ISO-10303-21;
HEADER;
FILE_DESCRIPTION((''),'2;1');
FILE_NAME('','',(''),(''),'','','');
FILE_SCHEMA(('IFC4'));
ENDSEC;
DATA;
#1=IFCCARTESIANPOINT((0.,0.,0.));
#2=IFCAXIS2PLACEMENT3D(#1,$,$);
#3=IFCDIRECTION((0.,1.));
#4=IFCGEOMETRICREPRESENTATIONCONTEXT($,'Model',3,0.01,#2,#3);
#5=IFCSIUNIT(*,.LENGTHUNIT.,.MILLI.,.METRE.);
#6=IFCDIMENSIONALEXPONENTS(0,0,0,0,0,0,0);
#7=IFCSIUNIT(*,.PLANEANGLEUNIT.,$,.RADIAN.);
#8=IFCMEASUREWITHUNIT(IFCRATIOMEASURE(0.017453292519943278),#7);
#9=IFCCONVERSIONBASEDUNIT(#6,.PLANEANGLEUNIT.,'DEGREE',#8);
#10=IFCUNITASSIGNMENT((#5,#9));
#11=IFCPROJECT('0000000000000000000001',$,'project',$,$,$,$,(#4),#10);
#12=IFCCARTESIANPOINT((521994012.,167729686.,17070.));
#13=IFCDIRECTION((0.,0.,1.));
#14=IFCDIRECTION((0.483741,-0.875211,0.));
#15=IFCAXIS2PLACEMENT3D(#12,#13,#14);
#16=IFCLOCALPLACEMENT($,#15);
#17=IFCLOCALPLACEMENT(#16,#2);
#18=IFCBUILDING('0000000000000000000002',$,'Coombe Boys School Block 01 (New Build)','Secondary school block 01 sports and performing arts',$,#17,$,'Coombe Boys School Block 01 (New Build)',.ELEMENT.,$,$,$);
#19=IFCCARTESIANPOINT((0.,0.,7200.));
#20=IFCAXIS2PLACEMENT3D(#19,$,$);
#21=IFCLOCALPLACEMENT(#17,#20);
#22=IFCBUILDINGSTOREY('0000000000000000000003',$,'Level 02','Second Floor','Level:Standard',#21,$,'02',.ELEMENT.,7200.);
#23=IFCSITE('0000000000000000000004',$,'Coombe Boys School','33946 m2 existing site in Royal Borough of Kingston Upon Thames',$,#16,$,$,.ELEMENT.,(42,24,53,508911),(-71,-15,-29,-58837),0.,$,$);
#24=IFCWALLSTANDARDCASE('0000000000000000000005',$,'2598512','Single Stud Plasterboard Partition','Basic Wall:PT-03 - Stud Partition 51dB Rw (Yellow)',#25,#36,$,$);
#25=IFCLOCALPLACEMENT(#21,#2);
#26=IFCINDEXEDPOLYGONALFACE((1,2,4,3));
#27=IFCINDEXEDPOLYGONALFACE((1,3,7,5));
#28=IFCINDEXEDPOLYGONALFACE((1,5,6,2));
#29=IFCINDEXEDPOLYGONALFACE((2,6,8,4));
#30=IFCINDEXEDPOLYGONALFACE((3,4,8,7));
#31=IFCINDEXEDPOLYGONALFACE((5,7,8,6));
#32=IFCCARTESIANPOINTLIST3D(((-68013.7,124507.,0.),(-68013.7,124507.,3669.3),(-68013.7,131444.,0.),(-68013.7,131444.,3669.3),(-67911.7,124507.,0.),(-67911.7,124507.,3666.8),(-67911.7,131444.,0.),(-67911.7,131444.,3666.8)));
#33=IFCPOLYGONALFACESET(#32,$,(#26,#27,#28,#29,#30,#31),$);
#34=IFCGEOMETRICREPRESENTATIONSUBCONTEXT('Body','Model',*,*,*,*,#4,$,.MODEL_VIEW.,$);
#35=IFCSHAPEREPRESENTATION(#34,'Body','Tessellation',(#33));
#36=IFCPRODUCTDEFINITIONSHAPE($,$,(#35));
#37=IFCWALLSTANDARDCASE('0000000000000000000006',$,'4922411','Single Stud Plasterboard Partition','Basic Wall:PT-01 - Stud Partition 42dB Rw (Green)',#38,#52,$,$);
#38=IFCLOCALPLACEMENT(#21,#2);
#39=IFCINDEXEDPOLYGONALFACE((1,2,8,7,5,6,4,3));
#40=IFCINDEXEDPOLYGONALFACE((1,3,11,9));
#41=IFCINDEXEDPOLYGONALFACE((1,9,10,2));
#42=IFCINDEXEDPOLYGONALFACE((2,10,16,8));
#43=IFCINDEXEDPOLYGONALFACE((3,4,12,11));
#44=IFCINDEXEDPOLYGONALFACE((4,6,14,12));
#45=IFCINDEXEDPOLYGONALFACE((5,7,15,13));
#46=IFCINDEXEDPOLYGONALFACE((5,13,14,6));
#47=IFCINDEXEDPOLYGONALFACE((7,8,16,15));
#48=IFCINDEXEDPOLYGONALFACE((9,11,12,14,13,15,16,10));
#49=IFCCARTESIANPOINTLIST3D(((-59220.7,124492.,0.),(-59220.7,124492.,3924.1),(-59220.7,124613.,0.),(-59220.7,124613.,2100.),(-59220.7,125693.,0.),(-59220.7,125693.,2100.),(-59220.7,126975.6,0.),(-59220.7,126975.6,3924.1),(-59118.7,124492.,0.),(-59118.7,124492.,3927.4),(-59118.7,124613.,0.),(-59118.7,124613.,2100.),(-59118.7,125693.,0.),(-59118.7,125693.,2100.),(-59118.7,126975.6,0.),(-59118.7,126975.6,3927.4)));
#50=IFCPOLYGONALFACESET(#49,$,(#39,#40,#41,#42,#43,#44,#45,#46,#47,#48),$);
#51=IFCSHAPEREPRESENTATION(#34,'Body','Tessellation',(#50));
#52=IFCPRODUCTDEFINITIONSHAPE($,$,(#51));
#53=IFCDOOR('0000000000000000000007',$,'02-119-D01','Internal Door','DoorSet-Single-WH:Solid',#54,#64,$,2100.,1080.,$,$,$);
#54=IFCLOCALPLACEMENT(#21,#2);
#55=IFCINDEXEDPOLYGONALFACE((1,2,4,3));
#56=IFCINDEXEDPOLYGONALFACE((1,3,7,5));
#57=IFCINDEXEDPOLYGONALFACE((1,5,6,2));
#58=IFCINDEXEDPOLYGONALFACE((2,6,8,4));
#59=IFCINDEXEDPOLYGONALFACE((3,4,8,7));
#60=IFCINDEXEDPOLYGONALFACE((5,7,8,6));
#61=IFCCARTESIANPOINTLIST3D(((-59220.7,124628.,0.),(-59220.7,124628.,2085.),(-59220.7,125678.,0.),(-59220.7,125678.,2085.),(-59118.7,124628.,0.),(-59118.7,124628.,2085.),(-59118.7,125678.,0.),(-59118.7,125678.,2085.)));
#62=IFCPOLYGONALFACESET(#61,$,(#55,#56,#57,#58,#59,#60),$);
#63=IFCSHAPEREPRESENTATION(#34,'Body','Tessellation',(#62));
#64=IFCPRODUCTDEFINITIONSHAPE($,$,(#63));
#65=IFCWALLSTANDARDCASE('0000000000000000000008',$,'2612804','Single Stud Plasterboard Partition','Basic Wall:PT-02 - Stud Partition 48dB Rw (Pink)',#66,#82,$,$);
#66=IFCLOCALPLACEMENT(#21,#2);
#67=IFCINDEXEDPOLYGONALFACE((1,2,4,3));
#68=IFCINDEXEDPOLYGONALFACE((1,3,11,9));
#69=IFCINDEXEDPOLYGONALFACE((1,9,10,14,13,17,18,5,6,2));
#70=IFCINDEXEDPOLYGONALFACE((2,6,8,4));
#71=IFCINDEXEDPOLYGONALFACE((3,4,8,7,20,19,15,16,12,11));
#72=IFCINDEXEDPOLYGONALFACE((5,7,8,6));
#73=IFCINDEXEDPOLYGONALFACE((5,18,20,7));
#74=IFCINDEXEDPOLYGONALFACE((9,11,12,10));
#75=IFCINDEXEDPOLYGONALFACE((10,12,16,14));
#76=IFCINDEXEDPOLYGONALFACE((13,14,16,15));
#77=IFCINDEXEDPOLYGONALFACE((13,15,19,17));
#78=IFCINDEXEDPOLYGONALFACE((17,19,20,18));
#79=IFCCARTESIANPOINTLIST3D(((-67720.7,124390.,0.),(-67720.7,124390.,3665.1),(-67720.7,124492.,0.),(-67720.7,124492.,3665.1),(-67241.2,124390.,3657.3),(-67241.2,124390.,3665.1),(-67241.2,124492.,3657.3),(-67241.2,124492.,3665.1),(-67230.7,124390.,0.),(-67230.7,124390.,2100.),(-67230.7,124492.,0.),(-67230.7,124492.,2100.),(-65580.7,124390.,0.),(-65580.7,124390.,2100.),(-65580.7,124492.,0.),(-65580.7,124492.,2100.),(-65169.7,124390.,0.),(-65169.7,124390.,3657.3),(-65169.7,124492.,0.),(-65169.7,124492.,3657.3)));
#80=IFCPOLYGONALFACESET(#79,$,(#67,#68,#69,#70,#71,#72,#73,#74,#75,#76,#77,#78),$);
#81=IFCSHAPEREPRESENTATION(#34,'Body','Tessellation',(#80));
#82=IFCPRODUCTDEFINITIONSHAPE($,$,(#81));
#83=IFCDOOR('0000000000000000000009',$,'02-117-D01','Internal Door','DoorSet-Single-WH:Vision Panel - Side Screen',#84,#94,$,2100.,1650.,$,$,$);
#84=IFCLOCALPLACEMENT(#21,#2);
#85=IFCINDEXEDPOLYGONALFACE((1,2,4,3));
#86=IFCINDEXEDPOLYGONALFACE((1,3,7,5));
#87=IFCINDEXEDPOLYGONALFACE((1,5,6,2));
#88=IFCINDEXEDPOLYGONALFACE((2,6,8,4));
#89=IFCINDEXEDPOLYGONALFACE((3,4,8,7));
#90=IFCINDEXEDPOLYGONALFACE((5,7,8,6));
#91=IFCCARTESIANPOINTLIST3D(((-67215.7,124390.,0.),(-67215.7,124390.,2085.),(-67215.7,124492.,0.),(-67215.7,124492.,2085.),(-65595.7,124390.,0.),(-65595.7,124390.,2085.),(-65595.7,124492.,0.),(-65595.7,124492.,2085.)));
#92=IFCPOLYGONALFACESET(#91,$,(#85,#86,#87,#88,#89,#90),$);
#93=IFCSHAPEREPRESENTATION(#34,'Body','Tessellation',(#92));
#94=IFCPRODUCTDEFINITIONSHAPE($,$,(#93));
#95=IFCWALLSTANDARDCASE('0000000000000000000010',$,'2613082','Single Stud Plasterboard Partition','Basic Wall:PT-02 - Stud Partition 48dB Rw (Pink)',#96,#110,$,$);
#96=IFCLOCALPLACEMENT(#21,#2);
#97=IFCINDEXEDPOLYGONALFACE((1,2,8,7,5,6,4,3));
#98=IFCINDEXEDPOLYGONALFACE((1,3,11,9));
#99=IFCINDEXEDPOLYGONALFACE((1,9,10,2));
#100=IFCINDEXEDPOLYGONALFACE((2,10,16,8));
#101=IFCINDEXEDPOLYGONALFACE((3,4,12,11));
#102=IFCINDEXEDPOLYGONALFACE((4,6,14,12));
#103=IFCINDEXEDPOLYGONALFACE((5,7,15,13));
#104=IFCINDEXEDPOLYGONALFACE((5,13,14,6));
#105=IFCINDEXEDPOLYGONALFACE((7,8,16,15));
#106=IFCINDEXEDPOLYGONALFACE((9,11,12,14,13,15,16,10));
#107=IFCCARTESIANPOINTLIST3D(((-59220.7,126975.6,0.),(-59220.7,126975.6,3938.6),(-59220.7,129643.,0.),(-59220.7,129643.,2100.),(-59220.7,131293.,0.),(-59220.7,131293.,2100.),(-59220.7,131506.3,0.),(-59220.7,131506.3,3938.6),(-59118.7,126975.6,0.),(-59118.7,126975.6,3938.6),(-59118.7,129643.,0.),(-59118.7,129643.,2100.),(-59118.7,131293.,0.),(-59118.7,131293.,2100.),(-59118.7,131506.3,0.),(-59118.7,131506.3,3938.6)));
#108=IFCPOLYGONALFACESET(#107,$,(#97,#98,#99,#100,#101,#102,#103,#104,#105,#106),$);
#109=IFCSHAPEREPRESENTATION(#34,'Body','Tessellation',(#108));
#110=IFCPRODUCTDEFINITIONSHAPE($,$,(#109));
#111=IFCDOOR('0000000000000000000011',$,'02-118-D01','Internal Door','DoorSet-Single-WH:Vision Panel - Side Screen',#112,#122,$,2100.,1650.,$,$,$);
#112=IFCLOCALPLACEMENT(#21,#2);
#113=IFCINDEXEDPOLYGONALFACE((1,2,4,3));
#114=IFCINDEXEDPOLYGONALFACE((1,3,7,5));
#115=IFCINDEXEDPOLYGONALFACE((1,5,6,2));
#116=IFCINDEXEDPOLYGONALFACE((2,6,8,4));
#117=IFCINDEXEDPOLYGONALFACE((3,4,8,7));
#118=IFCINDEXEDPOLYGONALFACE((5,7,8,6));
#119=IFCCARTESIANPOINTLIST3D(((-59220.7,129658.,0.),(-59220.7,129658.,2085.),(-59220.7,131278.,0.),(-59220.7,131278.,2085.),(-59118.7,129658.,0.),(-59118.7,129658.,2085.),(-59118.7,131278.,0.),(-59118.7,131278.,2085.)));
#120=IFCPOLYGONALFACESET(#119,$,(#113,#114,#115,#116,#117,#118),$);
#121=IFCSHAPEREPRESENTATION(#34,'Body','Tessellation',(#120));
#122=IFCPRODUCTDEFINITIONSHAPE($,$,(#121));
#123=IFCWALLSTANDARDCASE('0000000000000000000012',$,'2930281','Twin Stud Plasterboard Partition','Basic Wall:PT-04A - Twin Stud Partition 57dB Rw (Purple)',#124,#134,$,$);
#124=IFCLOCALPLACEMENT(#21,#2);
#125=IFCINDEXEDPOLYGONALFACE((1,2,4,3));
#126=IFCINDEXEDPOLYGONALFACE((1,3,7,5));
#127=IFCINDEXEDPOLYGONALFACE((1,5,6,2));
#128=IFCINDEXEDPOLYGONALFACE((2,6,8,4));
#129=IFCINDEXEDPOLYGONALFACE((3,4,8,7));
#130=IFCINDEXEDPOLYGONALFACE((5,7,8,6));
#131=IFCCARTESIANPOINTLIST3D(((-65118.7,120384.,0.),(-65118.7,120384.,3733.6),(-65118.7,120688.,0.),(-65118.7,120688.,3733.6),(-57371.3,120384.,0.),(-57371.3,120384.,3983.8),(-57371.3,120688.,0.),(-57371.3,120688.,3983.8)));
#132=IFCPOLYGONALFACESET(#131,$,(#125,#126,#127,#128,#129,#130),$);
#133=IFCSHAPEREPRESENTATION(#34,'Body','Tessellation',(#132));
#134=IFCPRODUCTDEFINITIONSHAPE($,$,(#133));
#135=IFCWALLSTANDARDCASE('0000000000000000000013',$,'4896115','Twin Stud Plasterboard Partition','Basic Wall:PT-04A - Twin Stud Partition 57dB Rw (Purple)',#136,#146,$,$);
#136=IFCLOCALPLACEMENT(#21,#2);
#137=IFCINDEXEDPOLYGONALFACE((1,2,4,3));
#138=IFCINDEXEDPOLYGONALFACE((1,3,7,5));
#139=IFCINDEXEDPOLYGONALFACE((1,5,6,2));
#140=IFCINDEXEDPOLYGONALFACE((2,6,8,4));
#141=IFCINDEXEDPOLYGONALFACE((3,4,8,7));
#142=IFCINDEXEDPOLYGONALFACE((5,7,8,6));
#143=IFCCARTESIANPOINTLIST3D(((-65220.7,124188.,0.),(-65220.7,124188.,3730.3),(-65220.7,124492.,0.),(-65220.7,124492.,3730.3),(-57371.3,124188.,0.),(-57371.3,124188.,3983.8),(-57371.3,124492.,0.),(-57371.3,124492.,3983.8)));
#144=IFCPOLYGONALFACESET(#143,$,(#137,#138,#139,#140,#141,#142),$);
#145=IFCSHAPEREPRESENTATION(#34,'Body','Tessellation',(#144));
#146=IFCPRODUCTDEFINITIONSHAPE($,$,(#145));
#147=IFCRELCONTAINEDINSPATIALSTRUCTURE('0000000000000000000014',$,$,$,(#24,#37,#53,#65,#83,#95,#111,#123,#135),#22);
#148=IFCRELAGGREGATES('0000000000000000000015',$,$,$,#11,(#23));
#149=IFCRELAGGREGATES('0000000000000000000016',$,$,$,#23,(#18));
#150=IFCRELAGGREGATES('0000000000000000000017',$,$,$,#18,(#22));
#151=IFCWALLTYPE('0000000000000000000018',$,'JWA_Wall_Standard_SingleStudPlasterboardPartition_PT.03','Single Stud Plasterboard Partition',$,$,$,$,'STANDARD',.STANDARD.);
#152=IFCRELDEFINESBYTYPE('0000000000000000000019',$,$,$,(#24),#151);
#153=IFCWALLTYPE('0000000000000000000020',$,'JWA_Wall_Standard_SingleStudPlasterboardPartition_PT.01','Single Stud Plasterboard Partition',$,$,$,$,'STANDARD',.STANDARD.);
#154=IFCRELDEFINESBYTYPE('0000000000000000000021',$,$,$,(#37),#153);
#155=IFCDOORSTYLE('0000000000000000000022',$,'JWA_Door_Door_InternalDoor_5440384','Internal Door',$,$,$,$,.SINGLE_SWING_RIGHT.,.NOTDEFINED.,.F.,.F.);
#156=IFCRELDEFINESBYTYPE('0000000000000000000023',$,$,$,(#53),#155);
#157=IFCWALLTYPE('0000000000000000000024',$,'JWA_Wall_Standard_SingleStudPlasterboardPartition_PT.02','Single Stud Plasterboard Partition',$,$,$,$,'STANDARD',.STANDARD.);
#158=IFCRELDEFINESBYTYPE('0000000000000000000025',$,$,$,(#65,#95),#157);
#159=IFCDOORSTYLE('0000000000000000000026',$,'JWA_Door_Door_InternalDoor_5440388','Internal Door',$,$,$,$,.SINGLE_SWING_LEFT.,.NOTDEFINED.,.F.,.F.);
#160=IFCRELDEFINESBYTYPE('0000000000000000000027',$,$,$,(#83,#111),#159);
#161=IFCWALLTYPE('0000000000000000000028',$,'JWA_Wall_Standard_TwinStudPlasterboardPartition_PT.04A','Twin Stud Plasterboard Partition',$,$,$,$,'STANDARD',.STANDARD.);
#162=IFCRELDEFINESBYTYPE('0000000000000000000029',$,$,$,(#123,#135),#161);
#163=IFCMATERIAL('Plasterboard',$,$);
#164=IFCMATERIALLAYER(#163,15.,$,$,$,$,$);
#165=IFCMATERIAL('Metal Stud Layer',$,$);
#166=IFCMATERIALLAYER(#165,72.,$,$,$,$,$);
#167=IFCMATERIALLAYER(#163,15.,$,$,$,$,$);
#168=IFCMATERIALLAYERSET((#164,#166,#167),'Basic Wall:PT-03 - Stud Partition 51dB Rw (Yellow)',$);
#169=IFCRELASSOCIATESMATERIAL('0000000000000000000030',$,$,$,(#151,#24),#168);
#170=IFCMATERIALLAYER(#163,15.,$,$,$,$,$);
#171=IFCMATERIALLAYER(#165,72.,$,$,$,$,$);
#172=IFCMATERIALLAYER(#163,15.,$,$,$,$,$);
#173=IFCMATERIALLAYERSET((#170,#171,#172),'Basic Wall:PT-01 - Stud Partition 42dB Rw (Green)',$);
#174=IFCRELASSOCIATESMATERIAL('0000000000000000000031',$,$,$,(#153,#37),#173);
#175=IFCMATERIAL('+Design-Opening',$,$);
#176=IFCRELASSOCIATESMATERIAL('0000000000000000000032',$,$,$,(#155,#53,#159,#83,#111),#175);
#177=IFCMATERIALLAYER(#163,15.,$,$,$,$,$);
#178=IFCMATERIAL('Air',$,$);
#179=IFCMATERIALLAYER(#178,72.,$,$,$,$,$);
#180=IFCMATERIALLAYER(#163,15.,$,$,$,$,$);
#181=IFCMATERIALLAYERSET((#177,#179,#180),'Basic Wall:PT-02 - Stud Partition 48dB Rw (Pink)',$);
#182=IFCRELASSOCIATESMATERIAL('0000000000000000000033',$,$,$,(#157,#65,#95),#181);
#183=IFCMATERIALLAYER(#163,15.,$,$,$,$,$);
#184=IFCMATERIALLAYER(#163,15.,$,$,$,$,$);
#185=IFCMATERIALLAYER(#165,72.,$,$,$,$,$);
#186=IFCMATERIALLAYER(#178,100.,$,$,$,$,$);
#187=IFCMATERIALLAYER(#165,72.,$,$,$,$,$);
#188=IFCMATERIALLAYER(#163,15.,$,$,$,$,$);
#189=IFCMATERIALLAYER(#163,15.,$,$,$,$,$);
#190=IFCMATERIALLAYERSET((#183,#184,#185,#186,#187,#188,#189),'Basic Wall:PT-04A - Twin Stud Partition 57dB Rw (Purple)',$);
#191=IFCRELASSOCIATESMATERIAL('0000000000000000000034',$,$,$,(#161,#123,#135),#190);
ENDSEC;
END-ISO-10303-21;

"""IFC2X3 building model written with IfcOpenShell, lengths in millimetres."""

from ifc_helpers import new_model, entity, si_unit, converted_unit, direction, frame, frame_2d, origin, origin_2d_with_axis, place, context, subcontext, project, spatial, polyline, rectangle, extrude, clip, bounded_halfspace, source, transform, mapped, material, layer, layer_set, layer_usage, type_object, type_shapes, element, fill, save


model = new_model("IFC2X3")

# Units and contexts
model_context = context("Model", 3, precision=0.01, world=origin(), true_north=direction((0.0, 1.0)))
body_context = subcontext(model_context, "Body", "Model", "MODEL_VIEW")
ifc_project = project(units=[si_unit("LENGTHUNIT", "METRE", prefix="MILLI"), converted_unit("PLANEANGLEUNIT", "DEGREE", entity("IfcRatioMeasure", 0.017453292519943278), si_unit("PLANEANGLEUNIT", "RADIAN"), dimensions=[0, 0, 0, 0, 0, 0, 0])], contexts=[model_context])

# Site, building, storey
site_placement = place(None, frame((521994012.0, 167729686.0, 17070.0), z_axis=(0.0, 0.0, 1.0), x_axis=(0.483741, -0.875211, 0.0)))
site = spatial("IfcSite", under=ifc_project, at=site_placement, Name="Coombe Boys School", Description="33946 m2 existing site in Royal Borough of Kingston Upon Thames", CompositionType="ELEMENT", RefLatitude=(42, 24, 53, 508911), RefLongitude=(-71, -15, -29, -58837), RefElevation=0.0)
building_placement = place(site_placement, origin())
building = spatial("IfcBuilding", under=site, at=building_placement, Name="Coombe Boys School Block 01 (New Build)", Description="Secondary school block 01 sports and performing arts", LongName="Coombe Boys School Block 01 (New Build)", CompositionType="ELEMENT")
storey_placement = place(building_placement, frame((0.0, 0.0, 7200.0)))
storey = spatial("IfcBuildingStorey", under=building, at=storey_placement, Name="Level 02", Description="Second Floor", ObjectType="Level:Standard", LongName="02", CompositionType="ELEMENT", Elevation=7200.0)

# Wall
ifc_material_1 = material(Name="Plasterboard")
ifc_layer_1 = layer(ifc_material_1, 15.0)
ifc_material_2 = material(Name="Metal Stud Layer")
ifc_layer_2 = layer(ifc_material_2, 72.0)
ifc_layer_3 = layer(ifc_material_1, 15.0)
ifc_layer_set_1 = layer_set([ifc_layer_1, ifc_layer_2, ifc_layer_3], Name="Basic Wall:PT-03 - Stud Partition 51dB Rw (Yellow)")
ifc_layer_usage_1 = layer_usage(ifc_layer_set_1, "AXIS2", "POSITIVE", -51.0)
wall_type_1 = type_object("IfcWallType", Name="JWA_Wall_Standard_SingleStudPlasterboardPartition_PT.03", Description="Single Stud Plasterboard Partition", ElementType="STANDARD", PredefinedType="STANDARD", material=ifc_layer_set_1)
wall_1_placement = place(storey_placement, frame((-67962.7, 131444.0, 0.0), z_axis=(0.0, 0.0, 1.0), x_axis=(0.0, -1.0, 0.0)))
element("IfcWallStandardCase", 1, at=wall_1_placement, inside=storey, type_object=wall_type_1, material=ifc_layer_usage_1, Name="2598512", Description="Single Stud Plasterboard Partition", ObjectType="Basic Wall:PT-03 - Stud Partition 51dB Rw (Yellow)", context=body_context, shape_type="Clipping", body=[
    clip(extrude(rectangle(XDim=6937.0, YDim=102.0, at=frame_2d((3468.5, 0.0), x_axis=(-1.0, 0.0))), origin(), (0.0, 0.0, 1.0), 3669.3), bounded_halfspace(frame((0.0, -51.0, 3669.3), z_axis=(0.0, 0.024956, 0.999689), x_axis=(-1.0, 0.0, 0.0)), False, frame((0.0, -51.0, 3669.3)), polyline([(0.0, 0.0), (6937.0, 0.0), (6937.0, 102.0), (0.0, 102.0), (0.0, 0.0)]))),
])

# Walls, openings, doors
ifc_layer_4 = layer(ifc_material_1, 15.0)
ifc_layer_5 = layer(ifc_material_2, 72.0)
ifc_layer_6 = layer(ifc_material_1, 15.0)
ifc_layer_set_2 = layer_set([ifc_layer_4, ifc_layer_5, ifc_layer_6], Name="Basic Wall:PT-01 - Stud Partition 42dB Rw (Green)")
ifc_layer_usage_2 = layer_usage(ifc_layer_set_2, "AXIS2", "POSITIVE", -51.0)
wall_type_2 = type_object("IfcWallType", Name="JWA_Wall_Standard_SingleStudPlasterboardPartition_PT.01", Description="Single Stud Plasterboard Partition", ElementType="STANDARD", PredefinedType="STANDARD", material=ifc_layer_set_2)
wall_2_placement = place(storey_placement, frame((-59169.7, 126975.6, 0.0), z_axis=(0.0, 0.0, 1.0), x_axis=(0.0, -1.0, 0.0)))
wall_2 = element("IfcWallStandardCase", 2, at=wall_2_placement, inside=storey, type_object=wall_type_2, material=ifc_layer_usage_2, Name="4922411", Description="Single Stud Plasterboard Partition", ObjectType="Basic Wall:PT-01 - Stud Partition 42dB Rw (Green)", context=body_context, shape_type="Clipping", body=[
    clip(extrude(rectangle(XDim=2483.6, YDim=102.0, at=frame_2d((1241.8, 0.0), x_axis=(1.0, 0.0))), origin(), (0.0, 0.0, 1.0), 3927.4), bounded_halfspace(frame((0.0, -51.0, 3924.1), z_axis=(0.0, -0.032283, 0.999479), x_axis=(1.0, 0.0, 0.0)), False, frame((0.0, -51.0, 3924.1)), polyline([(0.0, 0.0), (2483.6, 0.0), (2483.6, 102.0), (0.0, 102.0), (0.0, 0.0)]))),
])
opening_1_placement = place(wall_2_placement, frame((126975.6, 59169.7, 0.0), z_axis=(0.0, 0.0, 1.0), x_axis=(0.0, 1.0, 0.0)))
opening_1 = element("IfcOpeningElement", 3, at=opening_1_placement, cuts=wall_2, ObjectType="Opening", context=body_context, shape_type="SweptSolid", body=[
    extrude(rectangle(XDim=2100.0, YDim=1080.0, at=frame_2d((0.0, 0.0), x_axis=(1.0, 0.0))), frame((-59220.7, 125153.0, 1050.0), z_axis=(1.0, 0.0, 0.0), x_axis=(0.0, 0.0, -1.0)), (0.0, 0.0, 1.0), 102.0),
])
ifc_material_3 = material(Name="+Design-Opening")
door_style_1 = type_object("IfcDoorStyle", Name="JWA_Door_Door_InternalDoor_5440384", Description="Internal Door", ConstructionType="NOTDEFINED", OperationType="SINGLE_SWING_RIGHT", ParameterTakesPrecedence=False, Sizeable=False, material=ifc_material_3)
shared_shape_1 = source(origin(), body_context, "Body", "SweptSolid", [
    extrude(rectangle(XDim=102.0, YDim=1050.0, at=origin_2d_with_axis()), frame((125.0, 0.0, 0.0), z_axis=(0.0, 0.0, 1.0), x_axis=(0.0, 1.0, 0.0)), (0.0, 0.0, 1.0), 2085.0),
])
type_shapes(door_style_1, [shared_shape_1])
door_1_placement = place(opening_1_placement, frame((-59169.7, 125278.0, 0.0), z_axis=(0.0, 0.0, 1.0), x_axis=(0.0, -1.0, 0.0)))
door_1 = element("IfcDoor", 4, at=door_1_placement, inside=storey, type_object=door_style_1, material=ifc_material_3, Name="02-119-D01", Description="Internal Door", ObjectType="DoorSet-Single-WH:Solid", OverallHeight=2100.0, OverallWidth=1080.0, context=body_context, shape_type="MappedRepresentation", body=[
    mapped(shared_shape_1, transform((0.0, 0.0, 0.0), scale=1.0)),
])
fill(opening_1, door_1)
ifc_layer_7 = layer(ifc_material_1, 15.0)
ifc_material_4 = material(Name="Air")
ifc_layer_8 = layer(ifc_material_4, 72.0)
ifc_layer_9 = layer(ifc_material_1, 15.0)
ifc_layer_set_3 = layer_set([ifc_layer_7, ifc_layer_8, ifc_layer_9], Name="Basic Wall:PT-02 - Stud Partition 48dB Rw (Pink)")
ifc_layer_usage_3 = layer_usage(ifc_layer_set_3, "AXIS2", "NEGATIVE", 51.0)
wall_type_3 = type_object("IfcWallType", Name="JWA_Wall_Standard_SingleStudPlasterboardPartition_PT.02", Description="Single Stud Plasterboard Partition", ElementType="STANDARD", PredefinedType="STANDARD", material=ifc_layer_set_3)
wall_3_placement = place(storey_placement, frame((-67720.7, 124441.0, 0.0)))
wall_3 = element("IfcWallStandardCase", 5, at=wall_3_placement, inside=storey, type_object=wall_type_3, material=ifc_layer_usage_3, Name="2612804", Description="Single Stud Plasterboard Partition", ObjectType="Basic Wall:PT-02 - Stud Partition 48dB Rw (Pink)", context=body_context, shape_type="Clipping", body=[
    clip(clip(extrude(rectangle(XDim=2551.0, YDim=102.0, at=frame_2d((1275.5, 0.0), x_axis=(-1.0, 0.0))), origin(), (0.0, 0.0, 1.0), 3665.1), bounded_halfspace(frame((0.0, 51.0, 3665.1)), False, frame((0.0, 51.0, 3665.1)), polyline([(0.0, 0.0), (0.0, -102.0), (479.5, -102.0), (479.5, 0.0), (0.0, 0.0)]))), bounded_halfspace(frame((2551.0, -51.0, 3657.3), z_axis=(0.0, 0.0, 1.0), x_axis=(0.0, 1.0, 0.0)), False, frame((2551.0, -51.0, 3657.3)), polyline([(0.0, 0.0), (0.0, 102.0), (-2071.5, 102.0), (-2071.5, 0.0), (0.0, 0.0)]))),
])
opening_2_placement = place(wall_3_placement, frame((67720.7, -124441.0, 0.0)))
opening_2 = element("IfcOpeningElement", 6, at=opening_2_placement, cuts=wall_3, ObjectType="Opening", context=body_context, shape_type="SweptSolid", body=[
    extrude(rectangle(XDim=2100.0, YDim=1650.0, at=frame_2d((0.0, 0.0), x_axis=(0.0, 1.0))), frame((-66405.7, 124390.0, 1050.0), z_axis=(0.0, 1.0, 0.0), x_axis=(1.0, 0.0, 0.0)), (0.0, 0.0, 1.0), 102.0),
])
door_style_2 = type_object("IfcDoorStyle", Name="JWA_Door_Door_InternalDoor_5440388", Description="Internal Door", ConstructionType="NOTDEFINED", OperationType="SINGLE_SWING_LEFT", ParameterTakesPrecedence=False, Sizeable=False, material=ifc_material_3)
shared_shape_2 = source(origin(), body_context, "Body", "SweptSolid", [
    extrude(rectangle(XDim=1620.0, YDim=102.0, at=origin_2d_with_axis()), frame((-160.0, 0.0, 0.0), z_axis=(0.0, 0.0, 1.0), x_axis=(-1.0, 0.0, 0.0)), (0.0, 0.0, 1.0), 2085.0),
])
type_shapes(door_style_2, [shared_shape_2])
door_2_placement = place(opening_2_placement, frame((-66565.7, 124441.0, 0.0), z_axis=(0.0, 0.0, 1.0), x_axis=(-1.0, 0.0, 0.0)))
door_2 = element("IfcDoor", 7, at=door_2_placement, inside=storey, type_object=door_style_2, material=ifc_material_3, Name="02-117-D01", Description="Internal Door", ObjectType="DoorSet-Single-WH:Vision Panel - Side Screen", OverallHeight=2100.0, OverallWidth=1650.0, context=body_context, shape_type="MappedRepresentation", body=[
    mapped(shared_shape_2, transform((0.0, 0.0, 0.0), scale=1.0)),
])
fill(opening_2, door_2)
ifc_layer_usage_4 = layer_usage(ifc_layer_set_3, "AXIS2", "POSITIVE", -51.0)
wall_4_placement = place(storey_placement, frame((-59169.7, 131506.3, 0.0), z_axis=(0.0, 0.0, 1.0), x_axis=(0.0, -1.0, 0.0)))
wall_4 = element("IfcWallStandardCase", 8, at=wall_4_placement, inside=storey, type_object=wall_type_3, material=ifc_layer_usage_4, Name="2613082", Description="Single Stud Plasterboard Partition", ObjectType="Basic Wall:PT-02 - Stud Partition 48dB Rw (Pink)", context=body_context, shape_type="SweptSolid", body=[
    extrude(rectangle(XDim=4530.7, YDim=102.0, at=frame_2d((2265.4, 0.0), x_axis=(1.0, 0.0))), origin(), (0.0, 0.0, 1.0), 3938.6),
])
opening_3_placement = place(wall_4_placement, frame((131506.3, 59169.7, 0.0), z_axis=(0.0, 0.0, 1.0), x_axis=(0.0, 1.0, 0.0)))
opening_3 = element("IfcOpeningElement", 9, at=opening_3_placement, cuts=wall_4, ObjectType="Opening", context=body_context, shape_type="SweptSolid", body=[
    extrude(rectangle(XDim=2100.0, YDim=1650.0, at=frame_2d((0.0, 0.0), x_axis=(0.0, 1.0))), frame((-59220.7, 130468.0, 1050.0), z_axis=(1.0, 0.0, 0.0), x_axis=(0.0, -1.0, 0.0)), (0.0, 0.0, 1.0), 102.0),
])
door_3_placement = place(opening_3_placement, frame((-59169.7, 130628.0, 0.0), z_axis=(0.0, 0.0, 1.0), x_axis=(0.0, 1.0, 0.0)))
door_3 = element("IfcDoor", 10, at=door_3_placement, inside=storey, type_object=door_style_2, material=ifc_material_3, Name="02-118-D01", Description="Internal Door", ObjectType="DoorSet-Single-WH:Vision Panel - Side Screen", OverallHeight=2100.0, OverallWidth=1650.0, context=body_context, shape_type="MappedRepresentation", body=[
    mapped(shared_shape_2, transform((0.0, 0.0, 0.0), scale=1.0)),
])
fill(opening_3, door_3)

# Walls
ifc_layer_10 = layer(ifc_material_1, 15.0)
ifc_layer_11 = layer(ifc_material_1, 15.0)
ifc_layer_12 = layer(ifc_material_2, 72.0)
ifc_layer_13 = layer(ifc_material_4, 100.0)
ifc_layer_14 = layer(ifc_material_2, 72.0)
ifc_layer_15 = layer(ifc_material_1, 15.0)
ifc_layer_16 = layer(ifc_material_1, 15.0)
ifc_layer_set_4 = layer_set([ifc_layer_10, ifc_layer_11, ifc_layer_12, ifc_layer_13, ifc_layer_14, ifc_layer_15, ifc_layer_16], Name="Basic Wall:PT-04A - Twin Stud Partition 57dB Rw (Purple)")
ifc_layer_usage_5 = layer_usage(ifc_layer_set_4, "AXIS2", "NEGATIVE", 152.0)
wall_type_4 = type_object("IfcWallType", Name="JWA_Wall_Standard_TwinStudPlasterboardPartition_PT.04A", Description="Twin Stud Plasterboard Partition", ElementType="STANDARD", PredefinedType="STANDARD", material=ifc_layer_set_4)
wall_5_placement = place(storey_placement, frame((-57371.3, 120536.0, 0.0), z_axis=(0.0, 0.0, 1.0), x_axis=(-1.0, 0.0, 0.0)))
element("IfcWallStandardCase", 11, at=wall_5_placement, inside=storey, type_object=wall_type_4, material=ifc_layer_usage_5, Name="2930281", Description="Twin Stud Plasterboard Partition", ObjectType="Basic Wall:PT-04A - Twin Stud Partition 57dB Rw (Purple)", context=body_context, shape_type="Clipping", body=[
    clip(extrude(rectangle(XDim=7747.4, YDim=304.0, at=frame_2d((3873.7, 0.0), x_axis=(-1.0, 0.0))), origin(), (0.0, 0.0, 1.0), 3983.8), bounded_halfspace(frame((0.0, -152.0, 3983.8), z_axis=(0.032283, 0.0, 0.999479), x_axis=(0.0, 1.0, 0.0)), False, frame((0.0, -152.0, 3983.8)), polyline([(0.0, 0.0), (7747.4, 0.0), (7747.4, 304.0), (0.0, 304.0), (0.0, 0.0)]))),
])
wall_6_placement = place(storey_placement, frame((-65220.7, 124340.0, 0.0)))
element("IfcWallStandardCase", 12, at=wall_6_placement, inside=storey, type_object=wall_type_4, material=ifc_layer_usage_5, Name="4896115", Description="Twin Stud Plasterboard Partition", ObjectType="Basic Wall:PT-04A - Twin Stud Partition 57dB Rw (Purple)", context=body_context, shape_type="Clipping", body=[
    clip(extrude(rectangle(XDim=7849.4, YDim=304.0, at=frame_2d((3924.7, 0.0), x_axis=(-1.0, 0.0))), origin(), (0.0, 0.0, 1.0), 3983.8), bounded_halfspace(frame((0.0, -152.0, 3730.3), z_axis=(-0.032283, 0.0, 0.999479), x_axis=(0.0, -1.0, 0.0)), False, frame((0.0, -152.0, 3730.3)), polyline([(0.0, 0.0), (7849.4, 0.0), (7849.4, 304.0), (0.0, 304.0), (0.0, 0.0)]))),
])

save(model, "model.ifc")
